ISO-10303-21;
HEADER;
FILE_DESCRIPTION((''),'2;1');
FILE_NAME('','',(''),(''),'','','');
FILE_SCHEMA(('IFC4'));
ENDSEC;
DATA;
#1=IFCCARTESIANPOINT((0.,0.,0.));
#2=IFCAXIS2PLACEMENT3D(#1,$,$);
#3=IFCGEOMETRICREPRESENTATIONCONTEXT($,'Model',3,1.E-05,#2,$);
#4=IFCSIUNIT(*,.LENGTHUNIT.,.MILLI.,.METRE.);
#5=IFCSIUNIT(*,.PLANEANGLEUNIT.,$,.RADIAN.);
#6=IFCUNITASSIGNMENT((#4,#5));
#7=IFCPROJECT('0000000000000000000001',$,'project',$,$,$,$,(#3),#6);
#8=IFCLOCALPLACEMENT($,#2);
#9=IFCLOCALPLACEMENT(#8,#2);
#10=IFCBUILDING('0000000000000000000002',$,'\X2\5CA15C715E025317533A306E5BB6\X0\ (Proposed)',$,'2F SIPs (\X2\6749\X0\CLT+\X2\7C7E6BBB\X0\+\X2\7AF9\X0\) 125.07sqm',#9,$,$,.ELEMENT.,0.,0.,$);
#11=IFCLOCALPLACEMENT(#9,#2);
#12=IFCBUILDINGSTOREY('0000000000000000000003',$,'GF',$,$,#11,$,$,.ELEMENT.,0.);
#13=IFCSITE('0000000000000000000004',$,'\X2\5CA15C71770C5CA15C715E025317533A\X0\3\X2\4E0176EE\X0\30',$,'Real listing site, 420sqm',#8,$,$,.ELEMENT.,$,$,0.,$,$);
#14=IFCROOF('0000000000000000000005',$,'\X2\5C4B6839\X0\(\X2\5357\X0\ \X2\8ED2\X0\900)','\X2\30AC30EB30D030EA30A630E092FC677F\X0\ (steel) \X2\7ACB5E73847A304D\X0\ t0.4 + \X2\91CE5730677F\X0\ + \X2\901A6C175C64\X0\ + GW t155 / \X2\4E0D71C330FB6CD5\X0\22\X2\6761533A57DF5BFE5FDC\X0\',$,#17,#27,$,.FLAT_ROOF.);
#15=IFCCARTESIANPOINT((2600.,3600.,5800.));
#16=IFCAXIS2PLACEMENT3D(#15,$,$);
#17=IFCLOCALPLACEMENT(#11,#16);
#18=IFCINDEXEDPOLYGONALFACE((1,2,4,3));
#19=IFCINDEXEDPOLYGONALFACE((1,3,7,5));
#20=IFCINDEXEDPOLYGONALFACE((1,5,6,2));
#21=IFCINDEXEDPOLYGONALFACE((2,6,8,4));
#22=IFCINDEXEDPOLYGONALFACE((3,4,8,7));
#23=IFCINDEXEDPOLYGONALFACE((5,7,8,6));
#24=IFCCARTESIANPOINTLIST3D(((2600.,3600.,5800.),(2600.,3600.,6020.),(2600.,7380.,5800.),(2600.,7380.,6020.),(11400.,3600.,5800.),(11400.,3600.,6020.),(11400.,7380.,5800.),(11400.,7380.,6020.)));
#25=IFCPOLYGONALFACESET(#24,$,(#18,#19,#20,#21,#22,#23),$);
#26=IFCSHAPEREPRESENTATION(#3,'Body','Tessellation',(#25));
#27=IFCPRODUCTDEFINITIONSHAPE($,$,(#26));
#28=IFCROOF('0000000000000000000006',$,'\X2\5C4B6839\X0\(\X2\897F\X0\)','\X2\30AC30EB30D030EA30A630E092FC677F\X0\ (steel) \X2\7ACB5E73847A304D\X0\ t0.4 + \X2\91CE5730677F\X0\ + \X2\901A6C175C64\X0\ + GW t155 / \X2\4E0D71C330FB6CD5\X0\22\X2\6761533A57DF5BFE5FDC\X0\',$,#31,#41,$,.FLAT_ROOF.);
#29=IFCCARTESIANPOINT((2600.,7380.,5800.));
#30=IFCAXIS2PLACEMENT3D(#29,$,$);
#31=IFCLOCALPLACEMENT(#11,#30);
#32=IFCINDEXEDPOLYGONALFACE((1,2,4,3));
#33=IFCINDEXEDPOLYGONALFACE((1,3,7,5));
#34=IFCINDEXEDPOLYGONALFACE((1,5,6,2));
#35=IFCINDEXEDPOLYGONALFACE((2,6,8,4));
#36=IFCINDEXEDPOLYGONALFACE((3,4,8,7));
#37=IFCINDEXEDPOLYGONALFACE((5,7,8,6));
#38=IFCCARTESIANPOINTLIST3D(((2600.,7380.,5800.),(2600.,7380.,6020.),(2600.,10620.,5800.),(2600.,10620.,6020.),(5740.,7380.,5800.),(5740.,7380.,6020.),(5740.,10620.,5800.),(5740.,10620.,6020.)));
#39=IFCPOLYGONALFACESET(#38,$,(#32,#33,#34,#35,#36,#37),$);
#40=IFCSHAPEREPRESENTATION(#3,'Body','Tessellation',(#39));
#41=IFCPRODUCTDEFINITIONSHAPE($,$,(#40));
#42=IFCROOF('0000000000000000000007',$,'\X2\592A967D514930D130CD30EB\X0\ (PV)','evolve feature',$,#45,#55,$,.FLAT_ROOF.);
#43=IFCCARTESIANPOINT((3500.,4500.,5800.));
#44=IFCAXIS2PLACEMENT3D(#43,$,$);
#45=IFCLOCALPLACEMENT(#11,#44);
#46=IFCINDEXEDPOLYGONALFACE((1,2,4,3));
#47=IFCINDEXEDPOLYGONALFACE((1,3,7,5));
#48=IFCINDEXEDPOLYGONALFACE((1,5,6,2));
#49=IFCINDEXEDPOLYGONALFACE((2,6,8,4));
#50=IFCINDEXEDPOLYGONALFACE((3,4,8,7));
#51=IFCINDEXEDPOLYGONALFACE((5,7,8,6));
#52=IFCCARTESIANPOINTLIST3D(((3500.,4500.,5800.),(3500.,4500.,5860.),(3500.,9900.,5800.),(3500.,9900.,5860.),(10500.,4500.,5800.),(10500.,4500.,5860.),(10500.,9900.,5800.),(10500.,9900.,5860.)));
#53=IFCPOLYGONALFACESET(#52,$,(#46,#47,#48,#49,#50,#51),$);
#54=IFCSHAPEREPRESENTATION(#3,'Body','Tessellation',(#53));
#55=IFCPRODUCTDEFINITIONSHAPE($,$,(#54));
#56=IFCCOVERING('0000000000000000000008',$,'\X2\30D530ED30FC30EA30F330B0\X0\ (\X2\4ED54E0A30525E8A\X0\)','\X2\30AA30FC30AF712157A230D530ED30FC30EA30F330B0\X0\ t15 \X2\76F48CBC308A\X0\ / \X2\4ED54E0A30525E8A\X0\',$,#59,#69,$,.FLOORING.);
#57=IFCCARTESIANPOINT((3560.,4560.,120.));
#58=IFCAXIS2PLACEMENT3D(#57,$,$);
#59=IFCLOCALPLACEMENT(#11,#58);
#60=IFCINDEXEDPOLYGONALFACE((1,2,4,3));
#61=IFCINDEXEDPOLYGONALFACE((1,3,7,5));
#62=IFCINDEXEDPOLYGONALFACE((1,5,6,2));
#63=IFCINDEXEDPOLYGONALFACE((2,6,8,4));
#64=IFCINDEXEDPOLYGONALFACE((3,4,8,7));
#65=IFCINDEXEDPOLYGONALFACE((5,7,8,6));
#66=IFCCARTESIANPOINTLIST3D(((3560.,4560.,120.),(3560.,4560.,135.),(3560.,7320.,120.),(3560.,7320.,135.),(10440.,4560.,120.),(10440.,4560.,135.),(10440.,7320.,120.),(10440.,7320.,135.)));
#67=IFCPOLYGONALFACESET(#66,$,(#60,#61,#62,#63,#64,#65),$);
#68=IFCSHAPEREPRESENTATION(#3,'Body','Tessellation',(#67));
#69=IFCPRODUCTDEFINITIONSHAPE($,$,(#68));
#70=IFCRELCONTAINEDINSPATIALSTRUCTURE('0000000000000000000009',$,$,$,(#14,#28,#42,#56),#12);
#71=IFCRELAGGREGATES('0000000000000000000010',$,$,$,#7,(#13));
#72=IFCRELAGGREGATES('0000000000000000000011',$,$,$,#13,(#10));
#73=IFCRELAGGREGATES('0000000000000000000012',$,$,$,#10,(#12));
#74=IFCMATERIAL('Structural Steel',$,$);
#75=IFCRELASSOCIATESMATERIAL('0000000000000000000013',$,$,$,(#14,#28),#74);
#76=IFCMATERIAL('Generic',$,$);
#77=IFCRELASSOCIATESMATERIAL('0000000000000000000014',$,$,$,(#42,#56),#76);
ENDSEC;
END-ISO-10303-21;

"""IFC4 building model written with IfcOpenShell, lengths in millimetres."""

from ifc_helpers import new_model, si_unit, frame, frame_2d, origin, place, context, project, spatial, rectangle, extrude, material, element, save


model = new_model("IFC4")

# Units and contexts
model_context = context("Model", 3, precision=1e-05, world=origin())
ifc_project = project(units=[si_unit("LENGTHUNIT", "METRE", prefix="MILLI"), si_unit("PLANEANGLEUNIT", "RADIAN")], contexts=[model_context])

# Site, building, storey
site_placement = place(None, origin())
site = spatial("IfcSite", under=ifc_project, at=site_placement, Name="岡山県岡山市北区3丁目30", ObjectType="Real listing site, 420sqm", CompositionType="ELEMENT", RefElevation=0.0)
building_placement = place(site_placement, origin())
building = spatial("IfcBuilding", under=site, at=building_placement, Name="岡山市北区の家 (Proposed)", ObjectType="2F SIPs (杉CLT+籾殻+竹) 125.07sqm", CompositionType="ELEMENT", ElevationOfRefHeight=0.0, ElevationOfTerrain=0.0)
storey_placement = place(building_placement, origin())
storey = spatial("IfcBuildingStorey", under=building, at=storey_placement, Name="GF", CompositionType="ELEMENT", Elevation=0.0)

# Shared definitions
ifc_material_1 = material(Name="Generic")

# Roofs
ifc_material_2 = material(Name="Structural Steel")
roof_1_placement = place(storey_placement, frame((2600.0, 3600.0, 5800.0)))
element("IfcRoof", 1, at=roof_1_placement, inside=storey, material=ifc_material_2, Name="屋根(南 軒900)", Description="ガルバリウム鋼板 (steel) 立平葺き t0.4 + 野地板 + 通気層 + GW t155 / 不燃・法22条区域対応", PredefinedType="FLAT_ROOF", context=model_context, shape_type="SweptSolid", body=[
    extrude(rectangle(XDim=8800.0, YDim=3780.0, at=frame_2d((4400.0, 1890.0))), frame((2600.0, 3600.0, 5800.0)), (0.0, 0.0, 1.0), 220.0),
])
roof_2_placement = place(storey_placement, frame((2600.0, 7380.0, 5800.0)))
element("IfcRoof", 2, at=roof_2_placement, inside=storey, material=ifc_material_2, Name="屋根(西)", Description="ガルバリウム鋼板 (steel) 立平葺き t0.4 + 野地板 + 通気層 + GW t155 / 不燃・法22条区域対応", PredefinedType="FLAT_ROOF", context=model_context, shape_type="SweptSolid", body=[
    extrude(rectangle(XDim=3140.0, YDim=3240.0, at=frame_2d((1570.0, 1620.0))), frame((2600.0, 7380.0, 5800.0)), (0.0, 0.0, 1.0), 220.0),
])
roof_3_placement = place(storey_placement, frame((3500.0, 4500.0, 5800.0)))
element("IfcRoof", 3, at=roof_3_placement, inside=storey, material=ifc_material_1, Name="太陽光パネル (PV)", Description="evolve feature", PredefinedType="FLAT_ROOF", context=model_context, shape_type="SweptSolid", body=[
    extrude(rectangle(XDim=7000.0, YDim=5400.0, at=frame_2d((3500.0, 2700.0))), frame((3500.0, 4500.0, 5800.0)), (0.0, 0.0, 1.0), 60.0),
])

# Covering
covering_placement = place(storey_placement, frame((3560.0, 4560.0, 120.0)))
element("IfcCovering", 4, at=covering_placement, inside=storey, material=ifc_material_1, Name="フローリング (仕上げ床)", Description="オーク無垢フローリング t15 直貼り / 仕上げ床", PredefinedType="FLOORING", context=model_context, shape_type="SweptSolid", body=[
    extrude(rectangle(XDim=6880.0, YDim=2760.0, at=frame_2d((3440.0, 1380.0))), frame((3560.0, 4560.0, 120.0)), (0.0, 0.0, 1.0), 15.0),
])

save(model, "model.ifc")
